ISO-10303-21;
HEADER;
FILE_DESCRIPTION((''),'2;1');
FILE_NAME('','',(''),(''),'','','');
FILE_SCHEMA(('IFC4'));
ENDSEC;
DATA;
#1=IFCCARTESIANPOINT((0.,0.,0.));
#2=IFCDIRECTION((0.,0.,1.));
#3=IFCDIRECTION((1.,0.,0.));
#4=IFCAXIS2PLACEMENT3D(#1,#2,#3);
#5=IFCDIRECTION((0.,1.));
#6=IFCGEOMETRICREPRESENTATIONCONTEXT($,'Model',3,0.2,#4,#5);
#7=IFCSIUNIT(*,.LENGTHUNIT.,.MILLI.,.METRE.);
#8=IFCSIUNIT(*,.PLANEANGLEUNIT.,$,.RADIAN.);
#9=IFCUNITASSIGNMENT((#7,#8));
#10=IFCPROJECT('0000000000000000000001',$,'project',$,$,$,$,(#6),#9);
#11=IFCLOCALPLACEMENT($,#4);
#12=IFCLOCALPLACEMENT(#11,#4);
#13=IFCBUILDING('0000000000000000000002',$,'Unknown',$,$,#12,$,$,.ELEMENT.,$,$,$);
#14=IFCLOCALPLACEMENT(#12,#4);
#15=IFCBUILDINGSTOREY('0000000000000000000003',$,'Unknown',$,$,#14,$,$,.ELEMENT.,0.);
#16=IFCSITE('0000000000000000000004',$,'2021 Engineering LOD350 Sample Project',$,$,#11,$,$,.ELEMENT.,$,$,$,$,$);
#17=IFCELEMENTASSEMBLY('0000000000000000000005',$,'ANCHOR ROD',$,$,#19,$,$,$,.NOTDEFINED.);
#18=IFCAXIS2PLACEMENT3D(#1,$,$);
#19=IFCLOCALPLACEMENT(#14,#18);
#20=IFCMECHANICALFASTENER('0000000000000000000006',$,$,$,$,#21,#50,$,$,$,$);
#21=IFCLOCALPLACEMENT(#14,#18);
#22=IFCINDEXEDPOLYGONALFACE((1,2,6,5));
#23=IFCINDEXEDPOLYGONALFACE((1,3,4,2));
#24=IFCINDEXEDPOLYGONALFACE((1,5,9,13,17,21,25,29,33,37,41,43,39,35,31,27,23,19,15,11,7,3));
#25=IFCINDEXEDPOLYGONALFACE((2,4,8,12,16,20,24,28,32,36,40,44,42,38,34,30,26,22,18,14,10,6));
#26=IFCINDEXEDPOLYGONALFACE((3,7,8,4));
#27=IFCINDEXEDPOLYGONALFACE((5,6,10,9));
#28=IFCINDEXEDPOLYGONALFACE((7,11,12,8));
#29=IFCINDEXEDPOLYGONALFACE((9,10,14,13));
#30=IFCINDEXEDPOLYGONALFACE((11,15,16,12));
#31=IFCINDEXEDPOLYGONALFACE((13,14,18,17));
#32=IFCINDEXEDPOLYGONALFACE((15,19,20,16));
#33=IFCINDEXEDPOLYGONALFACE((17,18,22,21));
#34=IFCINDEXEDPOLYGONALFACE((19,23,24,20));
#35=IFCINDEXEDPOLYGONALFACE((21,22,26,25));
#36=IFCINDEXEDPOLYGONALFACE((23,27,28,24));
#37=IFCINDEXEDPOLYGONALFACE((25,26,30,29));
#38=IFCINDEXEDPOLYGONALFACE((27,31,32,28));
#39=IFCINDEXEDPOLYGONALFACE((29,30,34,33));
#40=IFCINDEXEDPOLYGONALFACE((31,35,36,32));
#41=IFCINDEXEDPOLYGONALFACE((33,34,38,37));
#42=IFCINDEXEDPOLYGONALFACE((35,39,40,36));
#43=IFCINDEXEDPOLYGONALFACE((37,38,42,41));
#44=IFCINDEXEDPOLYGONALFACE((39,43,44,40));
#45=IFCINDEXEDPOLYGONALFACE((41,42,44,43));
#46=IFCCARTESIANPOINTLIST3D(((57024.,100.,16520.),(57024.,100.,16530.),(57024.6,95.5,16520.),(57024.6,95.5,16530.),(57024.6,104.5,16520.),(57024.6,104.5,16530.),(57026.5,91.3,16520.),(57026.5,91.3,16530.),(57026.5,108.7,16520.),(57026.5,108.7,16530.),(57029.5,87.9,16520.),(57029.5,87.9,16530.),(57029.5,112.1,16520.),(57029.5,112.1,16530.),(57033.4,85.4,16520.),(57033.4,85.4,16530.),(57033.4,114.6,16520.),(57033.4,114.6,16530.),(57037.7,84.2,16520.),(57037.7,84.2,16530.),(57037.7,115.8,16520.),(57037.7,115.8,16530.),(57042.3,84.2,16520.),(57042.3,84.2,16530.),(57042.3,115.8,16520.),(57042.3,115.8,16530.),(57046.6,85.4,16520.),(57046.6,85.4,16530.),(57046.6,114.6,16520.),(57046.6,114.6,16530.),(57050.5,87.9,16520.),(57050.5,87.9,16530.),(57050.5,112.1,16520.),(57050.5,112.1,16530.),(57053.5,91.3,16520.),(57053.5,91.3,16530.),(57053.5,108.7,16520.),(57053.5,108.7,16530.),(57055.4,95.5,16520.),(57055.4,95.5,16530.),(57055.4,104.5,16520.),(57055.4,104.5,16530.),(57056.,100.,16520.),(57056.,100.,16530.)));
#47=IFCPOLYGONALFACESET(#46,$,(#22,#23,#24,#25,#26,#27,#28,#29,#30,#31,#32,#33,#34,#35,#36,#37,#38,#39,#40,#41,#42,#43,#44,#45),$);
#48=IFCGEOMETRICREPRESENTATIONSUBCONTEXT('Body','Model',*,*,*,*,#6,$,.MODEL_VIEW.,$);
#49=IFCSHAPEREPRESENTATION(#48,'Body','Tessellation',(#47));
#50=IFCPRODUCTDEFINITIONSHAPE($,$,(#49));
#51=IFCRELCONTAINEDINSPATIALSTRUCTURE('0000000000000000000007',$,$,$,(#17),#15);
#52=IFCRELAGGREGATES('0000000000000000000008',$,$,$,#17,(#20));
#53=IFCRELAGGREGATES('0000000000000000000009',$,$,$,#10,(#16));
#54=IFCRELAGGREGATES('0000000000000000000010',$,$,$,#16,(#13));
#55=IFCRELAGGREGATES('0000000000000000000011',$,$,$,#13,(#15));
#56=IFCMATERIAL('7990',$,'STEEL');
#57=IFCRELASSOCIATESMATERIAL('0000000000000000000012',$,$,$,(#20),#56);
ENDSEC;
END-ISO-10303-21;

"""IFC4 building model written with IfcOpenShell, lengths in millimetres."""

from ifc_helpers import new_model, si_unit, direction, frame, origin_with_axes, place, context, subcontext, project, spatial, arc, indexed_curve, outline, extrude, source, transform, mapped, material, element, aggregate, save


model = new_model("IFC4")

# Units and contexts
model_context = context("Model", 3, precision=0.2, world=origin_with_axes(), true_north=direction((0.0, 1.0)))
body_context = subcontext(model_context, "Body", "Model", "MODEL_VIEW")
ifc_project = project(units=[si_unit("LENGTHUNIT", "METRE", prefix="MILLI"), si_unit("PLANEANGLEUNIT", "RADIAN")], contexts=[model_context])

# Site, building, storey
site_placement = place(None, origin_with_axes())
site = spatial("IfcSite", under=ifc_project, at=site_placement, Name="2021 Engineering LOD350 Sample Project", CompositionType="ELEMENT")
building_placement = place(site_placement, origin_with_axes())
building = spatial("IfcBuilding", under=site, at=building_placement, Name="Unknown", CompositionType="ELEMENT")
storey_placement = place(building_placement, origin_with_axes())
storey = spatial("IfcBuildingStorey", under=building, at=storey_placement, Name="Unknown", CompositionType="ELEMENT", Elevation=0.0)

# Element assembly
assembly_1_placement = place(storey_placement, frame((57040.0, 100.0, 16730.0), z_axis=(1.0, 0.0, 0.0), x_axis=(0.0, 0.0, -1.0)))
assembly_1 = element("IfcElementAssembly", 1, at=assembly_1_placement, inside=storey, Name="ANCHOR ROD", PredefinedType="NOTDEFINED")

# Mechanical fastener
ifc_material_1 = material(Name="7990", Category="STEEL")
shared_shape_1 = source(origin_with_axes(), body_context, "Body", "SweptSolid", [
    extrude(outline(indexed_curve([(16.0, 0.0), (0.0, 16.0), (-16.0, 0.0), (0.0, -16.0)], segments=[arc(1, 2, 3), arc(3, 4, 1)])), frame((0.0, 0.0, 0.0), z_axis=(0.0, 0.0, -1.0), x_axis=(0.0, 1.0, 0.0)), (0.0, 0.0, 1.0), 10.0),
])
mechanical_fastener_1_placement = place(assembly_1_placement, frame((210.0, 0.0, 0.0), z_axis=(1.0, 0.0, 0.0), x_axis=(0.0, 1.0, 0.0)))
mechanical_fastener_1 = element("IfcMechanicalFastener", 2, at=mechanical_fastener_1_placement, material=ifc_material_1, context=body_context, shape_type="MappedRepresentation", body=[
    mapped(shared_shape_1, transform((0.0, 0.0, 0.0))),
])
aggregate(assembly_1, [mechanical_fastener_1])

save(model, "model.ifc")
